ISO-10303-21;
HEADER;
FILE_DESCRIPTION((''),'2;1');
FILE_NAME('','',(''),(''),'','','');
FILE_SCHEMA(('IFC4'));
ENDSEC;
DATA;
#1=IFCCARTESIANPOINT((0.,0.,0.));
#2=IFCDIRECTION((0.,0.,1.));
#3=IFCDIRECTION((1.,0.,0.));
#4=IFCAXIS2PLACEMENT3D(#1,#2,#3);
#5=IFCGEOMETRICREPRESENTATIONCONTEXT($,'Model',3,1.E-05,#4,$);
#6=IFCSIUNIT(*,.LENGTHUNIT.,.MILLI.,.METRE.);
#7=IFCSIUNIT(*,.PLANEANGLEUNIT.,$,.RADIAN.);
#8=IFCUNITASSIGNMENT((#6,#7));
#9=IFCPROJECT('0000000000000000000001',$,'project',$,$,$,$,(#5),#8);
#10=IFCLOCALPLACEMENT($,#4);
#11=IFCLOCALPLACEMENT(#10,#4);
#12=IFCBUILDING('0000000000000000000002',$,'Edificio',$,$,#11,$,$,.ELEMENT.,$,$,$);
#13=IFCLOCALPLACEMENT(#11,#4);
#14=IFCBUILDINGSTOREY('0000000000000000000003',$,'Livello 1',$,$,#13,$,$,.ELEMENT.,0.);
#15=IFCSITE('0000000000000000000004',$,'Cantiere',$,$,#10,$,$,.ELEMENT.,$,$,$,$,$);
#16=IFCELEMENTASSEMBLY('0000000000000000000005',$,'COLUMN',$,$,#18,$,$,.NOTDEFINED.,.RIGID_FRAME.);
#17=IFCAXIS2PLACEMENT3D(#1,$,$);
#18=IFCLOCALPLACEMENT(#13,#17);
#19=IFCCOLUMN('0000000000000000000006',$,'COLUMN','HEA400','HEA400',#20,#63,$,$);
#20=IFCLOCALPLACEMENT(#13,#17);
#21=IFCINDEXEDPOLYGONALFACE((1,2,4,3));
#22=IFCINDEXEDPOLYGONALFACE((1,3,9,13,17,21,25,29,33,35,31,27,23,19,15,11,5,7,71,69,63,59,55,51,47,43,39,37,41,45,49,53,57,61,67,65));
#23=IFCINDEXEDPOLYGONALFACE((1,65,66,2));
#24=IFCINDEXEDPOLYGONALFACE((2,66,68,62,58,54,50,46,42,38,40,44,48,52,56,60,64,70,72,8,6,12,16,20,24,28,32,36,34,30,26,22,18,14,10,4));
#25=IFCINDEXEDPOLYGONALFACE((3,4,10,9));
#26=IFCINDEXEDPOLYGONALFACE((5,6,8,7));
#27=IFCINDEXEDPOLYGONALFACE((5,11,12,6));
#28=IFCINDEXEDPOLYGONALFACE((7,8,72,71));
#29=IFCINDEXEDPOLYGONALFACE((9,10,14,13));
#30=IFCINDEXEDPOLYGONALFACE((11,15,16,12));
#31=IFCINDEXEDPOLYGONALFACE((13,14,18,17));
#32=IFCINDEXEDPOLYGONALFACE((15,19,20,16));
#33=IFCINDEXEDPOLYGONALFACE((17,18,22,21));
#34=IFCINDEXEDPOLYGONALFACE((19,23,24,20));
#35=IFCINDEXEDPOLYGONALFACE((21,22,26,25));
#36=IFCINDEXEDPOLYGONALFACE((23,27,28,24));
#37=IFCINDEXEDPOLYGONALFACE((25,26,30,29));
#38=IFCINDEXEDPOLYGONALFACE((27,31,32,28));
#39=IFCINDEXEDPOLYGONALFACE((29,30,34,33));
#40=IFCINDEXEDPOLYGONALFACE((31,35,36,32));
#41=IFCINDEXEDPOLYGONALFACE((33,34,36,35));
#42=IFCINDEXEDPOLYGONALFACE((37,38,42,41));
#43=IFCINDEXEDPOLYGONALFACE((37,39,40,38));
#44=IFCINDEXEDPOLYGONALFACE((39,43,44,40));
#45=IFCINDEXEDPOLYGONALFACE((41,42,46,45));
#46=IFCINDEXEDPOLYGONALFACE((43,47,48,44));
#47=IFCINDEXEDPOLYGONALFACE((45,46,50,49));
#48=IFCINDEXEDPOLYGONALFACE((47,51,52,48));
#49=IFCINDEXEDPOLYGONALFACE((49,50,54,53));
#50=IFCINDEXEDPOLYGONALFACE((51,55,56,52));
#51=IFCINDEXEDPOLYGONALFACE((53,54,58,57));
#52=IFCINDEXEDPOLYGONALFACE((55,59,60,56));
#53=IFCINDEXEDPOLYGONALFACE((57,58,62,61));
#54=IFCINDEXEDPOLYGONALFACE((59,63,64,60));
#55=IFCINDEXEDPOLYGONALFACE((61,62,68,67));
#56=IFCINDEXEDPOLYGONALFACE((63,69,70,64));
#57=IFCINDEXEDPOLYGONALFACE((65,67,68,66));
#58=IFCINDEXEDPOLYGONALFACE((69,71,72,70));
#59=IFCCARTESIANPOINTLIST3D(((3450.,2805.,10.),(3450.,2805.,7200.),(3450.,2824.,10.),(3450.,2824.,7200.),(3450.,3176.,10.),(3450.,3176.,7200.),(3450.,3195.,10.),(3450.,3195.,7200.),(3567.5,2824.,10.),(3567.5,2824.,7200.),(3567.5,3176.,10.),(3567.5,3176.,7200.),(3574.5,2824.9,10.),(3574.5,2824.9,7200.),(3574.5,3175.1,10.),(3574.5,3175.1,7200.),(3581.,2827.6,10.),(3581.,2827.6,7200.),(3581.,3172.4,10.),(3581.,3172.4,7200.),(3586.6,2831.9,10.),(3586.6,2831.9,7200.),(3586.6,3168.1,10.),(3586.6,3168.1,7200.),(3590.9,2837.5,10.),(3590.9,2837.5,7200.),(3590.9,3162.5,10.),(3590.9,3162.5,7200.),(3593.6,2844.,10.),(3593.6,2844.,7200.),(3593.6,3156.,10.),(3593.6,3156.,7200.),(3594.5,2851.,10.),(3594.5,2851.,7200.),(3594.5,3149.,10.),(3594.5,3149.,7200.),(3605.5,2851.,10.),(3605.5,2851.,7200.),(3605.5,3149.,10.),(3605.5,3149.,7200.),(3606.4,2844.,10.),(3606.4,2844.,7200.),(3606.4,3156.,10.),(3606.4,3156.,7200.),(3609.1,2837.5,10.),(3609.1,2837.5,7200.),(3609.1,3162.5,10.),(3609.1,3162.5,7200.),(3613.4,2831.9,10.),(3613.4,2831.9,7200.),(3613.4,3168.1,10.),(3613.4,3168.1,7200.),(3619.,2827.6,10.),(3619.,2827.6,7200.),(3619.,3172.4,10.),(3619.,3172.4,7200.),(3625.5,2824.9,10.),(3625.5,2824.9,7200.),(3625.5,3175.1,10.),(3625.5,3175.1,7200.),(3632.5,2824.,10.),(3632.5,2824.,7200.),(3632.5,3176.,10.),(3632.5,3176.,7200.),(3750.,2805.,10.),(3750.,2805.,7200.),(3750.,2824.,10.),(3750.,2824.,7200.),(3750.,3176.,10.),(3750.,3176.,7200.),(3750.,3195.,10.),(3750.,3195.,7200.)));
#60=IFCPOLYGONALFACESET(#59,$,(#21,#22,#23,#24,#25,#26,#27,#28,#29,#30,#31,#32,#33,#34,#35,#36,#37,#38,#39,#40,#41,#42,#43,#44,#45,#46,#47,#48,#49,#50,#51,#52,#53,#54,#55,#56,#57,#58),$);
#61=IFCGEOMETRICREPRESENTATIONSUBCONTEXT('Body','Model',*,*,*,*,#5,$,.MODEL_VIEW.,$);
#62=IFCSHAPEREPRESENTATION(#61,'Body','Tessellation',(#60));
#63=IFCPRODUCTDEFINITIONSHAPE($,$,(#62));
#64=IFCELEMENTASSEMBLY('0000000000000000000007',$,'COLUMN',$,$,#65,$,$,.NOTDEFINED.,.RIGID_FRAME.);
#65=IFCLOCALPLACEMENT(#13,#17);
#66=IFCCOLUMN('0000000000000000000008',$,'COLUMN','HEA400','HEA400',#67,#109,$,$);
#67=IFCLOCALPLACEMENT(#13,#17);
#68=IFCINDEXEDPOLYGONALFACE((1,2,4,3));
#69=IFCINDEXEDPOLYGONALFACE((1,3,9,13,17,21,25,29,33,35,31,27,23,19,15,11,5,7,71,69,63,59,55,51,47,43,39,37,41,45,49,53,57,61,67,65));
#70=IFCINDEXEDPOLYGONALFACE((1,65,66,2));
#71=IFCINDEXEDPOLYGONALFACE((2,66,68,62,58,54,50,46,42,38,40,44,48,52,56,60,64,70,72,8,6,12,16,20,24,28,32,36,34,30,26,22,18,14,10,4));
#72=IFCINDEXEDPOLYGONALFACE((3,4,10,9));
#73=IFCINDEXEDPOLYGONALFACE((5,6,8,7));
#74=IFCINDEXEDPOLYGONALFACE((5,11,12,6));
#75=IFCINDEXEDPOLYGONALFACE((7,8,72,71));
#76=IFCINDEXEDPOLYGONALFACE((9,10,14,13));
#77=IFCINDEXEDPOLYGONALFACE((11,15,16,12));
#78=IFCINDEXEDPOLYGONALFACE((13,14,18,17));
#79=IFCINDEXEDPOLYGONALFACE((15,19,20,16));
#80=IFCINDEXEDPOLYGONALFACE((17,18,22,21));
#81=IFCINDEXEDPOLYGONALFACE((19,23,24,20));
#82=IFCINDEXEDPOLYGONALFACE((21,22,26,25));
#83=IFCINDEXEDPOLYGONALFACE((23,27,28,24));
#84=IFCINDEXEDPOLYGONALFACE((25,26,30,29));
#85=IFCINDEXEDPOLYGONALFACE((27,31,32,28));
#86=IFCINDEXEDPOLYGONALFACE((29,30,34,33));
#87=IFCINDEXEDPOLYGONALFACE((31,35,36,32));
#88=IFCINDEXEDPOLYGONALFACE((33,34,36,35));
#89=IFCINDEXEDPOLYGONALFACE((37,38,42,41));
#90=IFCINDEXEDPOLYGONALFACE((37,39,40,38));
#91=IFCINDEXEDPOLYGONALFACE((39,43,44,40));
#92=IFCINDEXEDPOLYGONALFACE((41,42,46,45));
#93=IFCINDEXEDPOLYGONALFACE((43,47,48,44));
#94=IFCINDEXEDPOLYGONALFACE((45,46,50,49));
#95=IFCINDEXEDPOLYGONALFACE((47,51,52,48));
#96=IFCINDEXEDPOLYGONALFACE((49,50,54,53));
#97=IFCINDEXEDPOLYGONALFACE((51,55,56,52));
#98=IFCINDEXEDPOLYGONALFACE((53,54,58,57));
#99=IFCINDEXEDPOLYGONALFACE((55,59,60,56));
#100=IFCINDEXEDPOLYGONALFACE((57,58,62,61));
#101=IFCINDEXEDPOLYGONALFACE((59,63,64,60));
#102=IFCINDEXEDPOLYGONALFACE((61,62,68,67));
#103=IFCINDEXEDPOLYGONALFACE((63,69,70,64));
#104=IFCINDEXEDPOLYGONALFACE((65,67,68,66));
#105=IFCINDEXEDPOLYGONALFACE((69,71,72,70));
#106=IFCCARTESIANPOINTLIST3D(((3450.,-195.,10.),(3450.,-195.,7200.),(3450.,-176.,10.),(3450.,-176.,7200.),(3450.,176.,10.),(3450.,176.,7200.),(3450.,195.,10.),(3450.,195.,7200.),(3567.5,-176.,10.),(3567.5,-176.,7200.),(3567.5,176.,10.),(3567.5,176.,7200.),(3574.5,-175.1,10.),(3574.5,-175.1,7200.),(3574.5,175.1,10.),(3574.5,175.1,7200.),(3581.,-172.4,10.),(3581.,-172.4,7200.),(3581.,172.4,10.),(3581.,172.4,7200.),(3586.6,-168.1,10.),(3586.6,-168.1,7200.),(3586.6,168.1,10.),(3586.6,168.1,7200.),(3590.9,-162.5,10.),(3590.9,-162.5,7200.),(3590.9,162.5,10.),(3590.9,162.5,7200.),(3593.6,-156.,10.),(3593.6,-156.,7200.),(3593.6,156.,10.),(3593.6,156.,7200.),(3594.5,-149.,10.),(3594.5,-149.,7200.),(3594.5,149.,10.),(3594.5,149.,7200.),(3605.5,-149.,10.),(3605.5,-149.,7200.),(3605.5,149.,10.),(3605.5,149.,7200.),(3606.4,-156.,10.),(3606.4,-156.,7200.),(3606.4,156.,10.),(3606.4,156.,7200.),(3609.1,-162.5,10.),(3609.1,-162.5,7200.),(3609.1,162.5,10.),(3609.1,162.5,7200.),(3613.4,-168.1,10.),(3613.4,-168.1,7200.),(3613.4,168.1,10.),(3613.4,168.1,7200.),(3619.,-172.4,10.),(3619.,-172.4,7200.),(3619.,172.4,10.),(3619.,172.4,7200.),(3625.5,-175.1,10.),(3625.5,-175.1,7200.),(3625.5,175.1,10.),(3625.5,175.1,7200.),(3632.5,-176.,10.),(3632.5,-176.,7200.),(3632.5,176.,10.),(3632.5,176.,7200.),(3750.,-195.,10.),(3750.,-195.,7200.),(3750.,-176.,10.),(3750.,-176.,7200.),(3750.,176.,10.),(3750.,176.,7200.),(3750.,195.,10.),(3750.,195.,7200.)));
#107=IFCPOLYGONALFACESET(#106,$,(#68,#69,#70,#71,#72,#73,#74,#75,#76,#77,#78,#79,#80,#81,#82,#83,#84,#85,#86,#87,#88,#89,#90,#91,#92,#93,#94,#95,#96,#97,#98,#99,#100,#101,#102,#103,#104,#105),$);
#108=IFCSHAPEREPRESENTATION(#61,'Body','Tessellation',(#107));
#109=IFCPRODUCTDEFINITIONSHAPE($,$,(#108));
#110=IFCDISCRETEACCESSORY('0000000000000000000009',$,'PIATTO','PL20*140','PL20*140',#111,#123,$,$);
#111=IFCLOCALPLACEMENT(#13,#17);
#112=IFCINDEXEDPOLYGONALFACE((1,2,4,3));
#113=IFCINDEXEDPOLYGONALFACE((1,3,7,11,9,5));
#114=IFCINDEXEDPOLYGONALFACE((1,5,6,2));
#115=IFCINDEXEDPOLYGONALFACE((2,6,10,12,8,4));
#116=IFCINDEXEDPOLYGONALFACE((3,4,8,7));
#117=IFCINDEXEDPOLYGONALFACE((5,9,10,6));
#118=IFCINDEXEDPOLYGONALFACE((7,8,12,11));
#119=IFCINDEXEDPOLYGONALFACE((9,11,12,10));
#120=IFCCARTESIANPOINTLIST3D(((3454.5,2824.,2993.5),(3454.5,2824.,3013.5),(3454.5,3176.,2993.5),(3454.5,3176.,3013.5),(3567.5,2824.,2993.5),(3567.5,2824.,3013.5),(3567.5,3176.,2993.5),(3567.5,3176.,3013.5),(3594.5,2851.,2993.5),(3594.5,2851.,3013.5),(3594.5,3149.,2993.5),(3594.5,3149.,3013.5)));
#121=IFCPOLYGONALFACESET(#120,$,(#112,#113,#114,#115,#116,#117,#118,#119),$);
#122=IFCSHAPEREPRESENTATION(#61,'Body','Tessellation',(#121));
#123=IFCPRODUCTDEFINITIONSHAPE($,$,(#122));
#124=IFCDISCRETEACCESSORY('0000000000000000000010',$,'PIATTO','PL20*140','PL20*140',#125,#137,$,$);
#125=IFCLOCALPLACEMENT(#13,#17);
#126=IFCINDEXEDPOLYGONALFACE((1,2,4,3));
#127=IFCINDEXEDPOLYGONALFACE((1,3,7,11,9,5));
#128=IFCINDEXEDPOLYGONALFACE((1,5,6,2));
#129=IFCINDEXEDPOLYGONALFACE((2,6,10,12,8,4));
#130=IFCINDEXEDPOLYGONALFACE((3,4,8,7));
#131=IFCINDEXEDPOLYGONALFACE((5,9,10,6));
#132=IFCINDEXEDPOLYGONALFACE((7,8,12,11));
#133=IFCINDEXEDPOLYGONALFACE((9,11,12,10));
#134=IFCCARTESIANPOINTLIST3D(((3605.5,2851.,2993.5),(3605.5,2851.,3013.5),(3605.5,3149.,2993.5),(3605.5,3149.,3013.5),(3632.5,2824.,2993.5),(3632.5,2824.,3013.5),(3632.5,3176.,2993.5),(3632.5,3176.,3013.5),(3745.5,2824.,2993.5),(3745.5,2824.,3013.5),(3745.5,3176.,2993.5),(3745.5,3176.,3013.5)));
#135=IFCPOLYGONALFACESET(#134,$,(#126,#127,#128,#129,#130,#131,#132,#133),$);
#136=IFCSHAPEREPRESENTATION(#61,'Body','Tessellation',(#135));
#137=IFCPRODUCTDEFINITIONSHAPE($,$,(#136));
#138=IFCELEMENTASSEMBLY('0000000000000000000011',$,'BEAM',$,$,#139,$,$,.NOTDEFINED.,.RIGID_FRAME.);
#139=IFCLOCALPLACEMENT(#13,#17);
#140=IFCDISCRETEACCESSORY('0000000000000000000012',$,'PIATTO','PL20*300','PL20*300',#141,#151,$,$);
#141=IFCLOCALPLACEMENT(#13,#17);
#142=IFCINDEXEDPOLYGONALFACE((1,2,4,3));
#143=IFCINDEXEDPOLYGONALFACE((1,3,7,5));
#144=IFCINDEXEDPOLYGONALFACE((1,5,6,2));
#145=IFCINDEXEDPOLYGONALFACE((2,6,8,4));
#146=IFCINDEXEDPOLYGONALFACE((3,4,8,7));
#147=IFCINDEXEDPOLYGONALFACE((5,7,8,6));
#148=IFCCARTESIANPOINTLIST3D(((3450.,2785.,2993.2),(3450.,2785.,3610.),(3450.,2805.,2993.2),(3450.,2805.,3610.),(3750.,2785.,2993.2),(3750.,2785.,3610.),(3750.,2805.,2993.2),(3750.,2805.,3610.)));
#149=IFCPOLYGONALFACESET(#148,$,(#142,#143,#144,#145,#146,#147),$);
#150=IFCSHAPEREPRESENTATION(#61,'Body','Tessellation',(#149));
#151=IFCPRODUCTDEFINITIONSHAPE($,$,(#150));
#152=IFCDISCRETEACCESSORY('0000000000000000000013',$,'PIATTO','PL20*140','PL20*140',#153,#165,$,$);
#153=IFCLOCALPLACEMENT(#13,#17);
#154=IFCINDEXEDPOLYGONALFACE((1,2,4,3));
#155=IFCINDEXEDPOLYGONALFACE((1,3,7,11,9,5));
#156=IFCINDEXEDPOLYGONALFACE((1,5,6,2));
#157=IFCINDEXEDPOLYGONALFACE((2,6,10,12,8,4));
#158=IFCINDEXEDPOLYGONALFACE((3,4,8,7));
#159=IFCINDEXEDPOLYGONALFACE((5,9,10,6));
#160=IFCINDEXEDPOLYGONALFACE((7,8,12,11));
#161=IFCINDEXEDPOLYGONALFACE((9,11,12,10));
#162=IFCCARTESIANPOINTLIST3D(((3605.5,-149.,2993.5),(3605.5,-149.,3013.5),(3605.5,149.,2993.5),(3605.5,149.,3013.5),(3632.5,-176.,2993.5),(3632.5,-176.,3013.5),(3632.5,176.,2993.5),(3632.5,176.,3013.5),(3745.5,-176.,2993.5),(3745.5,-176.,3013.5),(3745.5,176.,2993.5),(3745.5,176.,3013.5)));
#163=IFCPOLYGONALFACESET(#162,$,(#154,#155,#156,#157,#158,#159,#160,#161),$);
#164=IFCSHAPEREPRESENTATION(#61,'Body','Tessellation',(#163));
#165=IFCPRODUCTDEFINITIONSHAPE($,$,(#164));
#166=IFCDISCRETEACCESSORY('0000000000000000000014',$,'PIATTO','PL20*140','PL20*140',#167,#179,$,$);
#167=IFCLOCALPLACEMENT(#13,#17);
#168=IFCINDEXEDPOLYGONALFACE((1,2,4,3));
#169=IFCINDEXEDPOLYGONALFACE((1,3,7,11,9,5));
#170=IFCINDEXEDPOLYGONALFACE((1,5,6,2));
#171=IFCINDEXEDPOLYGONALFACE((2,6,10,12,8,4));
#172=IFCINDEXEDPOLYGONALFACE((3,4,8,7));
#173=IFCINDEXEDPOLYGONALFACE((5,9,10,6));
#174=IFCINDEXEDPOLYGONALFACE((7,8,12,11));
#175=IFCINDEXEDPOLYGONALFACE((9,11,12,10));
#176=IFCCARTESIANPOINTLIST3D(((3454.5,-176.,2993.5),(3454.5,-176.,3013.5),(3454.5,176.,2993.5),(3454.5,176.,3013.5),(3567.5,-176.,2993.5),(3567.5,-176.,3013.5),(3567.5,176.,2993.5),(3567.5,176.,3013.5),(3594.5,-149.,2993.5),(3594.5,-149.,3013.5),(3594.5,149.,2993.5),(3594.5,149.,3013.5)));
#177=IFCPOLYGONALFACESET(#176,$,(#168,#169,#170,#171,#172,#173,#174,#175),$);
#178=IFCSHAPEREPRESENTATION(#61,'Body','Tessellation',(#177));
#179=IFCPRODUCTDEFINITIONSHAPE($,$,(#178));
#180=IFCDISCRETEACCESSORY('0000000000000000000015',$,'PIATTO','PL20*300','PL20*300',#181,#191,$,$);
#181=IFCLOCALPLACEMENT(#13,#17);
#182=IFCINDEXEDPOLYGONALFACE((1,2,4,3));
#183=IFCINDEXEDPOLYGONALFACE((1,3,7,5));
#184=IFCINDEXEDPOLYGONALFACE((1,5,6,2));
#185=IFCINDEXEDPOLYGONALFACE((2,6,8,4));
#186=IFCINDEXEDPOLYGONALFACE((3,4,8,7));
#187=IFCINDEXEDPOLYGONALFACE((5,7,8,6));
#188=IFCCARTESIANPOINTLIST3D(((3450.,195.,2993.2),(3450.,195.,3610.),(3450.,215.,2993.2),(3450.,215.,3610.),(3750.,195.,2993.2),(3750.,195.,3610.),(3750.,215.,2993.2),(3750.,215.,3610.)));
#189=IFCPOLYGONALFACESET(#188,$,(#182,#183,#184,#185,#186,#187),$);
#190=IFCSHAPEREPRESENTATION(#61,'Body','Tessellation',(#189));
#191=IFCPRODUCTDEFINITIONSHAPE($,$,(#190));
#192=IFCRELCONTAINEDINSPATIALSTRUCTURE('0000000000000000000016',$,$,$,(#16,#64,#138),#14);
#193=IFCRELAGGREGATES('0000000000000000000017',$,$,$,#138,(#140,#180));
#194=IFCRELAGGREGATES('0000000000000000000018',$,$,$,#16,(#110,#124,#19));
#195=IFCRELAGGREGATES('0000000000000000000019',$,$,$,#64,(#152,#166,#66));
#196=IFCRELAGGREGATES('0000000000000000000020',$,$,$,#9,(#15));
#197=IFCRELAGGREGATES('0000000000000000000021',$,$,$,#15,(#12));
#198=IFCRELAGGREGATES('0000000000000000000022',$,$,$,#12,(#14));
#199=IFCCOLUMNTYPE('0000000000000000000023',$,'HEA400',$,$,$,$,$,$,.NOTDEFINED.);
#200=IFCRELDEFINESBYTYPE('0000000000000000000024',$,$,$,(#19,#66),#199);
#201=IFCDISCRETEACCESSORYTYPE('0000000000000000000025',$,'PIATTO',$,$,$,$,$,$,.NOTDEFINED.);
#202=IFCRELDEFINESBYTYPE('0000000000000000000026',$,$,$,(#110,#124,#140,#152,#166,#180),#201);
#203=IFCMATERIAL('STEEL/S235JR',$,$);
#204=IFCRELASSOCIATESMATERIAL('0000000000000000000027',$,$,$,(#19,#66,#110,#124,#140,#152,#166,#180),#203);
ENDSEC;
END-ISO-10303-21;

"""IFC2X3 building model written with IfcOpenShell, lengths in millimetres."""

from ifc_helpers import new_model, si_unit, frame, origin_with_axes, origin_2d_with_axis, place, context, subcontext, project, spatial, polyline, i_section, outline, extrude, clip, halfspace, material, type_object, element, aggregate, save


model = new_model("IFC2X3")

# Units and contexts
model_context = context("Model", 3, precision=1e-05, world=origin_with_axes())
body_context = subcontext(model_context, "Body", "Model", "MODEL_VIEW")
ifc_project = project(units=[si_unit("LENGTHUNIT", "METRE", prefix="MILLI"), si_unit("PLANEANGLEUNIT", "RADIAN")], contexts=[model_context])

# Site, building, storey
site_placement = place(None, origin_with_axes())
site = spatial("IfcSite", under=ifc_project, at=site_placement, Name="Cantiere", CompositionType="ELEMENT")
building_placement = place(site_placement, origin_with_axes())
building = spatial("IfcBuilding", under=site, at=building_placement, Name="Edificio", CompositionType="ELEMENT")
storey_placement = place(building_placement, origin_with_axes())
storey = spatial("IfcBuildingStorey", under=building, at=storey_placement, Name="Livello 1", CompositionType="ELEMENT", Elevation=0.0)

# Element assemblies, columns
assembly_1_placement = place(storey_placement, origin_with_axes())
assembly_1 = element("IfcElementAssembly", 1, at=assembly_1_placement, inside=storey, Name="COLUMN", AssemblyPlace="NOTDEFINED", PredefinedType="RIGID_FRAME")
ifc_material_1 = material(Name="STEEL/S235JR")
column_type = type_object("IfcColumnType", Name="HEA400", PredefinedType="NOTDEFINED")
column_1_placement = place(assembly_1_placement, frame((3600.0, 3000.0, 0.0), z_axis=(0.0, 0.0, 1.0), x_axis=(0.0, 1.0, 0.0)))
column_1 = element("IfcColumn", 2, at=column_1_placement, type_object=column_type, material=ifc_material_1, Name="COLUMN", Description="HEA400", ObjectType="HEA400", context=body_context, shape_type="Clipping", body=[
    clip(extrude(i_section(OverallWidth=300.0, OverallDepth=390.0, WebThickness=11.0, FlangeThickness=19.0, FilletRadius=27.0, at=origin_2d_with_axis()), frame((0.0, 0.0, 7200.0), z_axis=(0.0, 0.0, -1.0), x_axis=(0.0, 1.0, 0.0)), (0.0, 0.0, 1.0), 7190.0), halfspace(frame((-195.0, 0.0, 10.0), z_axis=(0.0, 0.0, 1.0), x_axis=(0.0, 1.0, 0.0)), True)),
])
assembly_2_placement = place(storey_placement, origin_with_axes())
assembly_2 = element("IfcElementAssembly", 3, at=assembly_2_placement, inside=storey, Name="COLUMN", AssemblyPlace="NOTDEFINED", PredefinedType="RIGID_FRAME")
column_2_placement = place(assembly_2_placement, frame((3600.0, 0.0, 0.0), z_axis=(0.0, 0.0, 1.0), x_axis=(0.0, 1.0, 0.0)))
column_2 = element("IfcColumn", 4, at=column_2_placement, type_object=column_type, material=ifc_material_1, Name="COLUMN", Description="HEA400", ObjectType="HEA400", context=body_context, shape_type="Clipping", body=[
    clip(extrude(i_section(OverallWidth=300.0, OverallDepth=390.0, WebThickness=11.0, FlangeThickness=19.0, FilletRadius=27.0, at=origin_2d_with_axis()), frame((0.0, 0.0, 7200.0), z_axis=(0.0, 0.0, -1.0), x_axis=(0.0, 1.0, 0.0)), (0.0, 0.0, 1.0), 7190.0), halfspace(frame((-195.0, 0.0, 10.0), z_axis=(0.0, 0.0, 1.0), x_axis=(0.0, 1.0, 0.0)), True)),
])

# Discrete accessories
discrete_accessory_type_1 = type_object("IfcDiscreteAccessoryType", Name="PIATTO")
discrete_accessory_1_placement = place(assembly_1_placement, frame((3454.5, 2824.0, 3003.5), z_axis=(0.0, 0.0, 1.0), x_axis=(1.0, 0.0, 0.0)))
discrete_accessory_1 = element("IfcDiscreteAccessory", 5, at=discrete_accessory_1_placement, type_object=discrete_accessory_type_1, material=ifc_material_1, Name="PIATTO", Description="PL20*140", ObjectType="PL20*140", context=body_context, shape_type="SweptSolid", body=[
    extrude(outline(polyline([(0.0, 0.0), (113.0, 0.0), (140.0, 27.0), (140.0, 325.0), (113.0, 352.0), (0.0, 352.0), (0.0, 0.0)])), frame((0.0, 0.0, -10.0), z_axis=(0.0, 0.0, 1.0), x_axis=(1.0, 0.0, 0.0)), (0.0, 0.0, 1.0), 20.0),
])
discrete_accessory_2_placement = place(assembly_1_placement, frame((3745.5, 2824.0, 3003.5), z_axis=(0.0, 0.0, -1.0), x_axis=(-1.0, 0.0, 0.0)))
discrete_accessory_2 = element("IfcDiscreteAccessory", 6, at=discrete_accessory_2_placement, type_object=discrete_accessory_type_1, material=ifc_material_1, Name="PIATTO", Description="PL20*140", ObjectType="PL20*140", context=body_context, shape_type="SweptSolid", body=[
    extrude(outline(polyline([(0.0, 0.0), (113.0, 0.0), (140.0, 27.0), (140.0, 325.0), (113.0, 352.0), (0.0, 352.0), (0.0, 0.0)])), frame((0.0, 0.0, -10.0), z_axis=(0.0, 0.0, 1.0), x_axis=(1.0, 0.0, 0.0)), (0.0, 0.0, 1.0), 20.0),
])

# Element assembly, discrete accessory
assembly_3_placement = place(storey_placement, origin_with_axes())
assembly_3 = element("IfcElementAssembly", 7, at=assembly_3_placement, inside=storey, Name="BEAM", AssemblyPlace="NOTDEFINED", PredefinedType="RIGID_FRAME")
discrete_accessory_3_placement = place(assembly_3_placement, frame((3600.0, 2795.0, 2993.2), z_axis=(0.0, -1.0, 0.0), x_axis=(0.0, 0.0, 1.0)))
discrete_accessory_3 = element("IfcDiscreteAccessory", 8, at=discrete_accessory_3_placement, type_object=discrete_accessory_type_1, material=ifc_material_1, Name="PIATTO", Description="PL20*300", ObjectType="PL20*300", context=body_context, shape_type="SweptSolid", body=[
    extrude(outline(polyline([(0.0, 150.0), (616.8, 150.0), (616.8, -150.0), (0.0, -150.0), (0.0, 150.0)])), frame((0.0, 0.0, -10.0), z_axis=(0.0, 0.0, 1.0), x_axis=(1.0, 0.0, 0.0)), (0.0, 0.0, 1.0), 20.0),
])

# Discrete accessories
discrete_accessory_4_placement = place(assembly_2_placement, frame((3745.5, 176.0, 3003.5), z_axis=(0.0, 0.0, 1.0), x_axis=(-1.0, 0.0, 0.0)))
discrete_accessory_4 = element("IfcDiscreteAccessory", 9, at=discrete_accessory_4_placement, type_object=discrete_accessory_type_1, material=ifc_material_1, Name="PIATTO", Description="PL20*140", ObjectType="PL20*140", context=body_context, shape_type="SweptSolid", body=[
    extrude(outline(polyline([(0.0, 0.0), (113.0, 0.0), (140.0, 27.0), (140.0, 325.0), (113.0, 352.0), (0.0, 352.0), (0.0, 0.0)])), frame((0.0, 0.0, -10.0), z_axis=(0.0, 0.0, 1.0), x_axis=(1.0, 0.0, 0.0)), (0.0, 0.0, 1.0), 20.0),
])
discrete_accessory_5_placement = place(assembly_2_placement, frame((3454.5, 176.0, 3003.5), z_axis=(0.0, 0.0, -1.0), x_axis=(1.0, 0.0, 0.0)))
discrete_accessory_5 = element("IfcDiscreteAccessory", 10, at=discrete_accessory_5_placement, type_object=discrete_accessory_type_1, material=ifc_material_1, Name="PIATTO", Description="PL20*140", ObjectType="PL20*140", context=body_context, shape_type="SweptSolid", body=[
    extrude(outline(polyline([(0.0, 0.0), (113.0, 0.0), (140.0, 27.0), (140.0, 325.0), (113.0, 352.0), (0.0, 352.0), (0.0, 0.0)])), frame((0.0, 0.0, -10.0), z_axis=(0.0, 0.0, 1.0), x_axis=(1.0, 0.0, 0.0)), (0.0, 0.0, 1.0), 20.0),
])
discrete_accessory_6_placement = place(assembly_3_placement, frame((3600.0, 205.0, 2993.2), z_axis=(0.0, 1.0, 0.0), x_axis=(0.0, 0.0, 1.0)))
discrete_accessory_6 = element("IfcDiscreteAccessory", 11, at=discrete_accessory_6_placement, type_object=discrete_accessory_type_1, material=ifc_material_1, Name="PIATTO", Description="PL20*300", ObjectType="PL20*300", context=body_context, shape_type="SweptSolid", body=[
    extrude(outline(polyline([(0.0, -150.0), (0.0, 150.0), (616.8, 150.0), (616.8, -150.0), (0.0, -150.0)])), frame((0.0, 0.0, -10.0), z_axis=(0.0, 0.0, 1.0), x_axis=(1.0, 0.0, 0.0)), (0.0, 0.0, 1.0), 20.0),
])

aggregate(assembly_3, [discrete_accessory_3, discrete_accessory_6])

aggregate(assembly_1, [discrete_accessory_1, discrete_accessory_2, column_1])
aggregate(assembly_2, [discrete_accessory_4, discrete_accessory_5, column_2])

save(model, "model.ifc")
